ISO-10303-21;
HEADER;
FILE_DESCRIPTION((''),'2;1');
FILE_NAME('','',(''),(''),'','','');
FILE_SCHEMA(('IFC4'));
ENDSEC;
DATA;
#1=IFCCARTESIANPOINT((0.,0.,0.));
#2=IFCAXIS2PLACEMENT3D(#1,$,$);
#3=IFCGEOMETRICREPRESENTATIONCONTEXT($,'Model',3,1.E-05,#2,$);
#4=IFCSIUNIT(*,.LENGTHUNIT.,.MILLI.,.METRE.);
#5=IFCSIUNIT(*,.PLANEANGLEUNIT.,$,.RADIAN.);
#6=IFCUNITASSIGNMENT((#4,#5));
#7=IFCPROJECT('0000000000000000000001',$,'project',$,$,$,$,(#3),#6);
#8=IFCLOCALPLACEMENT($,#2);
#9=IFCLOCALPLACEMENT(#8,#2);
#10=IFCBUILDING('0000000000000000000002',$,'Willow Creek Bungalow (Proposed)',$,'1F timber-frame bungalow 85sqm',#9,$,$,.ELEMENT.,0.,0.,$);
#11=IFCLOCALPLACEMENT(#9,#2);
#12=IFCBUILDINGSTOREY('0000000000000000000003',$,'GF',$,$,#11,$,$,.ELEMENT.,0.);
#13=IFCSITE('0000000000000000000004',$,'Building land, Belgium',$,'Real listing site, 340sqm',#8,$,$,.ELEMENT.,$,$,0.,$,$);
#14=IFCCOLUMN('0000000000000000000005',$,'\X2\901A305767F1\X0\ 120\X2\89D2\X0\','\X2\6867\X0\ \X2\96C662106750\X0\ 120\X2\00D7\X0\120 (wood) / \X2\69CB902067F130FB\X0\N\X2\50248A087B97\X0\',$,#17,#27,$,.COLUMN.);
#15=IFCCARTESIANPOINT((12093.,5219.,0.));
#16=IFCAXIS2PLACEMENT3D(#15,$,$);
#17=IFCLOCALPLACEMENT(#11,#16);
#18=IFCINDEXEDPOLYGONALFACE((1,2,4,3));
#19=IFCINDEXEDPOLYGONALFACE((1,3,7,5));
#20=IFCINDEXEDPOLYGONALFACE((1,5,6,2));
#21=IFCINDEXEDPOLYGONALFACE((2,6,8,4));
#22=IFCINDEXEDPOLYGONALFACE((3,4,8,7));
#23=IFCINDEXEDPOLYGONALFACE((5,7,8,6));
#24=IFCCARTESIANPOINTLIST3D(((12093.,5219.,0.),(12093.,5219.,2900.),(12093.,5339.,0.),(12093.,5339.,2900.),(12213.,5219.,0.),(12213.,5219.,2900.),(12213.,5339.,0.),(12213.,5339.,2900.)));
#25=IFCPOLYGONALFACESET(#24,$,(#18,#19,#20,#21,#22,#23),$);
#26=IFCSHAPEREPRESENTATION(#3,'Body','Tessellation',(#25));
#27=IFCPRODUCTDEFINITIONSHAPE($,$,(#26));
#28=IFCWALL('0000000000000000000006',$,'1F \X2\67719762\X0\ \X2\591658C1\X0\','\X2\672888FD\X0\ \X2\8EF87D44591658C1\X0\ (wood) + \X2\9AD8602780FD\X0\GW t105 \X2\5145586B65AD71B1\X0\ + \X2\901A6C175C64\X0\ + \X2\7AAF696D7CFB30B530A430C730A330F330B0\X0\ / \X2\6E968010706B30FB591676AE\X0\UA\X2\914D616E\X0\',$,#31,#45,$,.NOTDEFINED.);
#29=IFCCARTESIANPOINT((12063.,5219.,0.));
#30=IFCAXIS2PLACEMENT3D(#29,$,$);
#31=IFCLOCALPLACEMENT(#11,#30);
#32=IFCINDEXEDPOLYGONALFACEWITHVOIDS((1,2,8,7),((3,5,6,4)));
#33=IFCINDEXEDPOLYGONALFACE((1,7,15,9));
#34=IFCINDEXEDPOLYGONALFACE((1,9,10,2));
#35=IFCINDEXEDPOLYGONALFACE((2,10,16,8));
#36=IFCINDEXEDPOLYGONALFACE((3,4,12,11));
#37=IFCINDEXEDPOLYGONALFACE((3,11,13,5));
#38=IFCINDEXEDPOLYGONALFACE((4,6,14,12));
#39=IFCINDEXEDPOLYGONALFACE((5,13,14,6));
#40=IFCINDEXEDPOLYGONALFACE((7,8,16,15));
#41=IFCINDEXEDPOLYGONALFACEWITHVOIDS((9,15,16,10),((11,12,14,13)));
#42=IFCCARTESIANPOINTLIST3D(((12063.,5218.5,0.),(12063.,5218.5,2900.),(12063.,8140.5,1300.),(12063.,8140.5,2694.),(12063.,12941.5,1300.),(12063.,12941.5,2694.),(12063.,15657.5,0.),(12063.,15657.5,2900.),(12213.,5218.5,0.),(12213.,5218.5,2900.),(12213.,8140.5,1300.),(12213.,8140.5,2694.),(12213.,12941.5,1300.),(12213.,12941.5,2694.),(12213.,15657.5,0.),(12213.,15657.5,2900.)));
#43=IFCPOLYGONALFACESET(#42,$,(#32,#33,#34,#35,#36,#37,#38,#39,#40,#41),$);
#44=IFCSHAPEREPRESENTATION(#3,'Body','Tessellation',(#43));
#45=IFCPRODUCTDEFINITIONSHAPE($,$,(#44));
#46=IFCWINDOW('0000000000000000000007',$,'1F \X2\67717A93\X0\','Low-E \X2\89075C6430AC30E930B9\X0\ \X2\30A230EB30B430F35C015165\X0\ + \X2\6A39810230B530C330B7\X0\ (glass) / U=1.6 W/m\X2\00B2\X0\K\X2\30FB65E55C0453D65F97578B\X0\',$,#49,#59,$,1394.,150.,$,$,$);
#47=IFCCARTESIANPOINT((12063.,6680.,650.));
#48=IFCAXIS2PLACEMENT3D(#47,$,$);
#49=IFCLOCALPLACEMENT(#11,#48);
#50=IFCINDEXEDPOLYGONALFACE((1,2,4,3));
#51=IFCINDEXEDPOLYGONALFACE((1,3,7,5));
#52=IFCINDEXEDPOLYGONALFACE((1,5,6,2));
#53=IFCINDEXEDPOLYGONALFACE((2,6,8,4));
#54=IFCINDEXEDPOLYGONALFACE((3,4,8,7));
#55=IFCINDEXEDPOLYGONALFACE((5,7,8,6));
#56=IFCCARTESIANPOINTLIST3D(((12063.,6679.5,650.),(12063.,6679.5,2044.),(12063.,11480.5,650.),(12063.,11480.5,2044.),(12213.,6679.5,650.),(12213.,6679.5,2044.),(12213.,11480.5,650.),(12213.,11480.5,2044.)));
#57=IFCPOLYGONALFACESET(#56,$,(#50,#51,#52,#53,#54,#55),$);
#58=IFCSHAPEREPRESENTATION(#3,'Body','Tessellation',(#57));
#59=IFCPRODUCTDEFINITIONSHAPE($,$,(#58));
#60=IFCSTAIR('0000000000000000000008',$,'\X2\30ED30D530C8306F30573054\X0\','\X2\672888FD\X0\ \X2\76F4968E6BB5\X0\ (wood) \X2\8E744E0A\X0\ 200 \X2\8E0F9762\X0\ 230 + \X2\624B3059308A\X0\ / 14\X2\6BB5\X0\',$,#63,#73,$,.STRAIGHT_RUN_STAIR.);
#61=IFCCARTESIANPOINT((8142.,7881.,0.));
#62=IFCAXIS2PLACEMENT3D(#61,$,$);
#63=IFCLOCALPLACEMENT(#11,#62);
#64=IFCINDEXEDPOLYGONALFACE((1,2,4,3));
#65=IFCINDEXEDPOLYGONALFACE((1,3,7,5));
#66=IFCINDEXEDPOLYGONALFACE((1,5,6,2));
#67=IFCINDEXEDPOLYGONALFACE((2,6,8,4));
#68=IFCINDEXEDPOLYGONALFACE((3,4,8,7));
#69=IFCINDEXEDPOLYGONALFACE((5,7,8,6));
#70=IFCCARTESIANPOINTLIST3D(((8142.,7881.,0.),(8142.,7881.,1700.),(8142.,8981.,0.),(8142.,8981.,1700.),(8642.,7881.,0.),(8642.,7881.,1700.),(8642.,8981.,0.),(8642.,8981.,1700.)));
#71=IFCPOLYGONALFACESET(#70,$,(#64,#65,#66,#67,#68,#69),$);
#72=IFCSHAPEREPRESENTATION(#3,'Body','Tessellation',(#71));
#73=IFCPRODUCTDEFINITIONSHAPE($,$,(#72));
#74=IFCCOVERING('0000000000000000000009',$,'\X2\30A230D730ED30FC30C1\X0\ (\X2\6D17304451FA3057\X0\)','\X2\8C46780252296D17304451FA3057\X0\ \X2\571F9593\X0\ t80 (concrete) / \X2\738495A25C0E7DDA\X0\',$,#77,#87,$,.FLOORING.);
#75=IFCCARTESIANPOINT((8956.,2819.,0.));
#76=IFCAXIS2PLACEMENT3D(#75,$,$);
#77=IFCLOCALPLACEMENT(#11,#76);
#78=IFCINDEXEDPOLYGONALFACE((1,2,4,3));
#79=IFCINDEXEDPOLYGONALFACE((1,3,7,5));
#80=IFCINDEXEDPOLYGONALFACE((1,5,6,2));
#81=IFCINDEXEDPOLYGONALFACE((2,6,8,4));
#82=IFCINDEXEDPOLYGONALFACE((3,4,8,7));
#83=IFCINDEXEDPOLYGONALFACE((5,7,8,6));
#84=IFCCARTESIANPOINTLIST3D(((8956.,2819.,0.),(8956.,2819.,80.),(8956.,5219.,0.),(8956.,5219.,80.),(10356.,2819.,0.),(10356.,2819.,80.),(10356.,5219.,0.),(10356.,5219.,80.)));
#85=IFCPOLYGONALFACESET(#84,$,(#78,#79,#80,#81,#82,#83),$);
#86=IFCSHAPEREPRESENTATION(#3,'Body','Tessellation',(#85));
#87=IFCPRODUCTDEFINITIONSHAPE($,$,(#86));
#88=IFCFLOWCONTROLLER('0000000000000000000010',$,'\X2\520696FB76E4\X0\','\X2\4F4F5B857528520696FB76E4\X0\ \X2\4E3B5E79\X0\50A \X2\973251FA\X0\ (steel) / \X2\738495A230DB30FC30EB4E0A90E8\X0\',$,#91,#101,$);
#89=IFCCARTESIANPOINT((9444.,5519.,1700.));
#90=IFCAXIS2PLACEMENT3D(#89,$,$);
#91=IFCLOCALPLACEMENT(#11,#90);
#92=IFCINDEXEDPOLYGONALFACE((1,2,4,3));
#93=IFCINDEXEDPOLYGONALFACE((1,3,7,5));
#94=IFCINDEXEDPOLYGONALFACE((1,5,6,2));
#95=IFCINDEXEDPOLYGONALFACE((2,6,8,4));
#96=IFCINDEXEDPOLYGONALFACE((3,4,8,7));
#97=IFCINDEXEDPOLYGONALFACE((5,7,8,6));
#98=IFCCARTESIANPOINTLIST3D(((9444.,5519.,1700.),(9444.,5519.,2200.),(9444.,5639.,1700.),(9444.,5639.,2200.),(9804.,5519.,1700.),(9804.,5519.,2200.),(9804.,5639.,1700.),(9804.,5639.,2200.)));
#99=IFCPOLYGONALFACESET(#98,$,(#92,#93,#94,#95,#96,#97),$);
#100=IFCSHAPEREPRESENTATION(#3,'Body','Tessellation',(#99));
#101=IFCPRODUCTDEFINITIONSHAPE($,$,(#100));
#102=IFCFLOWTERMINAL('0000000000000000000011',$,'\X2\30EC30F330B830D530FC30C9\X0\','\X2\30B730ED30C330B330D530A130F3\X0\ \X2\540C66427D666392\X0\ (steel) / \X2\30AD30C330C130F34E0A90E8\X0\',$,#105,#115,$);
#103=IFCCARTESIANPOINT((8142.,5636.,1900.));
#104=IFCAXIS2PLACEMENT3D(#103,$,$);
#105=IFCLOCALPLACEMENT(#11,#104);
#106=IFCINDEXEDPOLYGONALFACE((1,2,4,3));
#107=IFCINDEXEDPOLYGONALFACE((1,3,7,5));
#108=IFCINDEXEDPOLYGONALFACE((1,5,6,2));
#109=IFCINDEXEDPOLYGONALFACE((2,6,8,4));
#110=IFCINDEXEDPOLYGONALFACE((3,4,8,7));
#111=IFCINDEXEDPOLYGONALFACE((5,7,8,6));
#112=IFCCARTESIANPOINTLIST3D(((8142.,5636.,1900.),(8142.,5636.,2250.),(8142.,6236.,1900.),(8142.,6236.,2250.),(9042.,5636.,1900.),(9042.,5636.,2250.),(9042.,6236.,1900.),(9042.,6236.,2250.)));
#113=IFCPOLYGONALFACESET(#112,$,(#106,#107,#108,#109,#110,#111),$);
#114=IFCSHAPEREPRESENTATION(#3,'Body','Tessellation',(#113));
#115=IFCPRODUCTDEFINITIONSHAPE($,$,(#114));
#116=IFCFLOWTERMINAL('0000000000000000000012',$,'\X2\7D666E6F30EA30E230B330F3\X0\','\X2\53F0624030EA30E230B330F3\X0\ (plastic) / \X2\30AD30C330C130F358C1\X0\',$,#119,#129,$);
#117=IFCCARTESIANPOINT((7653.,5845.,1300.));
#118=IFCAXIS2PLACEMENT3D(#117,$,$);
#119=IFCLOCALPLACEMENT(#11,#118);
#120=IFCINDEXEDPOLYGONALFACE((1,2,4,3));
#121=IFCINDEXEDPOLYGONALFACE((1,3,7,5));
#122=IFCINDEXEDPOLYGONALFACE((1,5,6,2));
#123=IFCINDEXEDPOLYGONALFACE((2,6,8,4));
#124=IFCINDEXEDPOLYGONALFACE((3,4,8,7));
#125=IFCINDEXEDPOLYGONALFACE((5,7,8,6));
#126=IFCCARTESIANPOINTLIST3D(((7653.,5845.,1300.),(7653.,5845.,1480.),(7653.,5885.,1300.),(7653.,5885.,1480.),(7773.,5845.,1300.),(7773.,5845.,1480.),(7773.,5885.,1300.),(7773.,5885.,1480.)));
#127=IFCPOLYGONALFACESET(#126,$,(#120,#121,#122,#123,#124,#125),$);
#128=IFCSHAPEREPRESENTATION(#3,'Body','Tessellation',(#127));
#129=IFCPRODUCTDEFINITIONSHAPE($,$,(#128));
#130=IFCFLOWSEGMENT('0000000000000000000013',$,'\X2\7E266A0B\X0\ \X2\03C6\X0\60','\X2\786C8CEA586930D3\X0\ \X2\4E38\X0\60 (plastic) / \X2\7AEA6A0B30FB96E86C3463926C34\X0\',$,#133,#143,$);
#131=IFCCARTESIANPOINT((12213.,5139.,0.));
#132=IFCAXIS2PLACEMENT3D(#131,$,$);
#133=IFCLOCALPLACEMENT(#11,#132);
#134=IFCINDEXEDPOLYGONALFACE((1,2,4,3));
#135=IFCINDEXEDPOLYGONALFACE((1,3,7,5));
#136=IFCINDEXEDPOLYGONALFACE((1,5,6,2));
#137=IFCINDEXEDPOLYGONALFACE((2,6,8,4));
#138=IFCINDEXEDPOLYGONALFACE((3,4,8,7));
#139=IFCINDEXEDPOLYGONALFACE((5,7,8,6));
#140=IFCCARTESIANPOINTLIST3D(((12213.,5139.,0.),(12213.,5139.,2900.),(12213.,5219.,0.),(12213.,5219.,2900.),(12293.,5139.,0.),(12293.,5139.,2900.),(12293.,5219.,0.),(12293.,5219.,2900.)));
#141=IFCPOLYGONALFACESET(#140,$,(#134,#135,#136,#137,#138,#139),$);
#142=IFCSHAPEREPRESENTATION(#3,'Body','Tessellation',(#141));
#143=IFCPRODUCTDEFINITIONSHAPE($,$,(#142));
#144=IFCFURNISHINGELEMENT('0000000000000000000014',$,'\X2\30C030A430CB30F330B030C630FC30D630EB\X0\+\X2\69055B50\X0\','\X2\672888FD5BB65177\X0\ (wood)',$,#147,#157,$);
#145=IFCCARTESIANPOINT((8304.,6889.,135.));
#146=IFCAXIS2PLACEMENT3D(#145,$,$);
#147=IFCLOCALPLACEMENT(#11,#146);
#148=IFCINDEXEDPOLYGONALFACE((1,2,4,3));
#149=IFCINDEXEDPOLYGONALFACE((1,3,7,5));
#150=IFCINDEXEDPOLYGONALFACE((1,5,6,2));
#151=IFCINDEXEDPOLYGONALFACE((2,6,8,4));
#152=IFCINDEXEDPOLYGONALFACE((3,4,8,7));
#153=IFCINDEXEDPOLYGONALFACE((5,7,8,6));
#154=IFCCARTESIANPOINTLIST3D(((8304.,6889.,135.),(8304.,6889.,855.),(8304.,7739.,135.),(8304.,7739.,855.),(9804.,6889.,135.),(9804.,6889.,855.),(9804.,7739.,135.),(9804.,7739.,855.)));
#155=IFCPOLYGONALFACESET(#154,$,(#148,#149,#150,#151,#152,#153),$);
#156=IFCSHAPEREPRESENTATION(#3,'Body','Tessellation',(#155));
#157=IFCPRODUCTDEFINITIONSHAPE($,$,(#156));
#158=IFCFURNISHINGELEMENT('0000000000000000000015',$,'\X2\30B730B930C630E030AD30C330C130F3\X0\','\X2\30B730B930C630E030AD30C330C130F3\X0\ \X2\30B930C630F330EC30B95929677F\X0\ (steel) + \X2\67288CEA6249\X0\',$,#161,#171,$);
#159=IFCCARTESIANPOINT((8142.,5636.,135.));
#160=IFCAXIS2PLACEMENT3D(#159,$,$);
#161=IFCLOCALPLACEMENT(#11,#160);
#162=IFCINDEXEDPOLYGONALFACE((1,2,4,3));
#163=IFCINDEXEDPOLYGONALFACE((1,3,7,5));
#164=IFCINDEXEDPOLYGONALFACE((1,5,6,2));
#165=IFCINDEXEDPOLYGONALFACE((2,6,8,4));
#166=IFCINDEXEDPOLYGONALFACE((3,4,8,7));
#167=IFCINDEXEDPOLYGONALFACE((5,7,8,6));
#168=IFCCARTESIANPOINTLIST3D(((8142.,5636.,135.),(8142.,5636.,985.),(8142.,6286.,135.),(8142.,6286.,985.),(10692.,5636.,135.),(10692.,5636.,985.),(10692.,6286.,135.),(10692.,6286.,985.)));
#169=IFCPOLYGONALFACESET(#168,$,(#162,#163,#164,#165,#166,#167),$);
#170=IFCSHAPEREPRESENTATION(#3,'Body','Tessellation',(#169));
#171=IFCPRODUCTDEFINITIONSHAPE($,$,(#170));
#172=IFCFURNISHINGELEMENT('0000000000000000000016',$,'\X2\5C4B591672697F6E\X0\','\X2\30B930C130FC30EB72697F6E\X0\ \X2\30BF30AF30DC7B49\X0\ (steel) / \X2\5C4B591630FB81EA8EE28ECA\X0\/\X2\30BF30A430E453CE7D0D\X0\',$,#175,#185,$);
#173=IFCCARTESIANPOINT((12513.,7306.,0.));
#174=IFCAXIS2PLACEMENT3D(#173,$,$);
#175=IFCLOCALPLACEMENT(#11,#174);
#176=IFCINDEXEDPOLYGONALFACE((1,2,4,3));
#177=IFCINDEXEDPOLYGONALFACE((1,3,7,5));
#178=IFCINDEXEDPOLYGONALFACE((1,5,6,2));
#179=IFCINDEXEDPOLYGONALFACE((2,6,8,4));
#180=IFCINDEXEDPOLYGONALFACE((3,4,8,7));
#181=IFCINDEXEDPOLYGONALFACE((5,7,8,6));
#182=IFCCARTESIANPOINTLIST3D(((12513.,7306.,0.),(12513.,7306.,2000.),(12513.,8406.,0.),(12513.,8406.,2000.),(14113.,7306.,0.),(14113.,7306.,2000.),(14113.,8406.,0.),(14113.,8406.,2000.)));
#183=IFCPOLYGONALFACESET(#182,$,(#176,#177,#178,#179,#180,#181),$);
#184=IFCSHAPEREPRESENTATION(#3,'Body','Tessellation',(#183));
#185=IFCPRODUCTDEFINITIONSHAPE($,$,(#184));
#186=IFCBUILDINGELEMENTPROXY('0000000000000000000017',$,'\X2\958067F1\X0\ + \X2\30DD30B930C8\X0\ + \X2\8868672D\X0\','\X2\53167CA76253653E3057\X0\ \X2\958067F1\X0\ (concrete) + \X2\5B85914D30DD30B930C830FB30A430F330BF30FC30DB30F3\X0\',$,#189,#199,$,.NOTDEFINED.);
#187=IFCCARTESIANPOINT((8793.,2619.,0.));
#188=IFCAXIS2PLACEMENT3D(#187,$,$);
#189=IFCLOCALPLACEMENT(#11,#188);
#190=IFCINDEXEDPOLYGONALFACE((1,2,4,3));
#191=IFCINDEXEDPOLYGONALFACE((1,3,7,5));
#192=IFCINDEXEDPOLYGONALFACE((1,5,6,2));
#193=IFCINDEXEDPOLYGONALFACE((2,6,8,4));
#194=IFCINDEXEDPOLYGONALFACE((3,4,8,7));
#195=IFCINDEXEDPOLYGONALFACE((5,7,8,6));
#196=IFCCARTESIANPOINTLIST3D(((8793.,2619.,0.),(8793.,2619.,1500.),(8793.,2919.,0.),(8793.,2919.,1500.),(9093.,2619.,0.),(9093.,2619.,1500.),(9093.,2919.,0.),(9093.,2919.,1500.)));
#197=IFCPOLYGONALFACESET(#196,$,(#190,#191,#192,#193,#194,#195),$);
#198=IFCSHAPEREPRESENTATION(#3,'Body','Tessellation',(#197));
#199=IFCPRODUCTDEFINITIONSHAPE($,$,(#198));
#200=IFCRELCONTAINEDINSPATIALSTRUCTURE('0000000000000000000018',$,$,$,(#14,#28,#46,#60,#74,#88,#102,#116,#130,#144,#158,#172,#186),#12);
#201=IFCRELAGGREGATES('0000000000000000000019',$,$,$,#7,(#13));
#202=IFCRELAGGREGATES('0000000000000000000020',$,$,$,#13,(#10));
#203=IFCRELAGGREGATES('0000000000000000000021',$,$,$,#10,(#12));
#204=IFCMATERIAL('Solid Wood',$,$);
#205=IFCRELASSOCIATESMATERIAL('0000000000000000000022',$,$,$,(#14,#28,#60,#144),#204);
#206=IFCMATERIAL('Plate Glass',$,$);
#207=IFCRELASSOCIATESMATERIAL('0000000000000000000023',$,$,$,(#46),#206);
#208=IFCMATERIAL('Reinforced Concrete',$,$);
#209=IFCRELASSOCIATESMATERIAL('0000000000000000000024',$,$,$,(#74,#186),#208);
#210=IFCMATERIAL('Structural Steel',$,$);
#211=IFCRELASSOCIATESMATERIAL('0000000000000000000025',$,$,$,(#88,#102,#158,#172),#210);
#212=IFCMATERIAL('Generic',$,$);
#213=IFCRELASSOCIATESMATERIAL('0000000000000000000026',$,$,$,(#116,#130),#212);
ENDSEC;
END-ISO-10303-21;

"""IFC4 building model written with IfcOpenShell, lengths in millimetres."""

from ifc_helpers import new_model, si_unit, frame, frame_2d, origin, place, context, project, spatial, rectangle, extrude, material, element, fill, save


model = new_model("IFC4")

# Units and contexts
model_context = context("Model", 3, precision=1e-05, world=origin())
ifc_project = project(units=[si_unit("LENGTHUNIT", "METRE", prefix="MILLI"), si_unit("PLANEANGLEUNIT", "RADIAN")], contexts=[model_context])

# Site, building, storey
site_placement = place(None, origin())
site = spatial("IfcSite", under=ifc_project, at=site_placement, Name="Building land, Belgium", ObjectType="Real listing site, 340sqm", CompositionType="ELEMENT", RefElevation=0.0)
building_placement = place(site_placement, origin())
building = spatial("IfcBuilding", under=site, at=building_placement, Name="Willow Creek Bungalow (Proposed)", ObjectType="1F timber-frame bungalow 85sqm", CompositionType="ELEMENT", ElevationOfRefHeight=0.0, ElevationOfTerrain=0.0)
storey_placement = place(building_placement, origin())
storey = spatial("IfcBuildingStorey", under=building, at=storey_placement, Name="GF", CompositionType="ELEMENT", Elevation=0.0)

# Column
ifc_material_1 = material(Name="Solid Wood")
column_1_placement = place(storey_placement, frame((12093.0, 5219.0, 0.0)))
element("IfcColumn", 1, at=column_1_placement, inside=storey, material=ifc_material_1, Name="通し柱 120角", Description="桧 集成材 120×120 (wood) / 構造柱・N値計算", PredefinedType="COLUMN", context=model_context, shape_type="SweptSolid", body=[
    extrude(rectangle(XDim=120.0, YDim=120.0, at=frame_2d((60.0, 60.0))), frame((12093.0, 5219.0, 0.0)), (0.0, 0.0, 1.0), 2900.0),
])

# Wall, opening, window
wall_1_placement = place(storey_placement, frame((12063.0, 5219.0, 0.0)))
wall_1 = element("IfcWall", 2, at=wall_1_placement, inside=storey, material=ifc_material_1, Name="1F 東面 外壁", Description="木製 軸組外壁 (wood) + 高性能GW t105 充填断熱 + 通気層 + 窯業系サイディング / 準耐火・外皮UA配慮", PredefinedType="NOTDEFINED", context=model_context, shape_type="SweptSolid", body=[
    extrude(rectangle(XDim=150.0, YDim=10439.0, at=frame_2d((75.0, 5219.0))), frame((12063.0, 5219.0, 0.0)), (0.0, 0.0, 1.0), 2900.0),
])
opening_placement = place(storey_placement, frame((12063.0, 6680.0, 650.0)))
opening = element("IfcOpeningElement", 3, at=opening_placement, cuts=wall_1, PredefinedType="NOTDEFINED", context=model_context, shape_type="SweptSolid", body=[
    extrude(rectangle(XDim=150.0, YDim=4801.0, at=frame_2d((75.0, 2400.0))), frame((12063.0, 6680.0, 650.0)), (0.0, 0.0, 1.0), 1394.0),
])
ifc_material_2 = material(Name="Plate Glass")
window_placement = place(storey_placement, frame((12063.0, 6680.0, 650.0)))
window = element("IfcWindow", 4, at=window_placement, inside=storey, material=ifc_material_2, Name="1F 東窓", Description="Low-E 複層ガラス アルゴン封入 + 樹脂サッシ (glass) / U=1.6 W/m²K・日射取得型", OverallHeight=1394.0, OverallWidth=150.0, context=model_context, shape_type="SweptSolid", body=[
    extrude(rectangle(XDim=150.0, YDim=4801.0, at=frame_2d((75.0, 2400.0))), frame((12063.0, 6680.0, 650.0)), (0.0, 0.0, 1.0), 1394.0),
])
fill(opening, window)

# Stair
stair_placement = place(storey_placement, frame((8142.0, 7881.0, 0.0)))
element("IfcStair", 5, at=stair_placement, inside=storey, material=ifc_material_1, Name="ロフトはしご", Description="木製 直階段 (wood) 蹴上 200 踏面 230 + 手すり / 14段", PredefinedType="STRAIGHT_RUN_STAIR", context=model_context, shape_type="SweptSolid", body=[
    extrude(rectangle(XDim=500.0, YDim=1100.0, at=frame_2d((250.0, 550.0))), frame((8142.0, 7881.0, 0.0)), (0.0, 0.0, 1.0), 1700.0),
])

# Covering
ifc_material_3 = material(Name="Reinforced Concrete")
covering_placement = place(storey_placement, frame((8956.0, 2819.0, 0.0)))
element("IfcCovering", 6, at=covering_placement, inside=storey, material=ifc_material_3, Name="アプローチ (洗い出し)", Description="豆砂利洗い出し 土間 t80 (concrete) / 玄関導線", PredefinedType="FLOORING", context=model_context, shape_type="SweptSolid", body=[
    extrude(rectangle(XDim=1400.0, YDim=2400.0, at=frame_2d((700.0, 1200.0))), frame((8956.0, 2819.0, 0.0)), (0.0, 0.0, 1.0), 80.0),
])

# Flow controller
ifc_material_4 = material(Name="Structural Steel")
flow_controller_placement = place(storey_placement, frame((9444.0, 5519.0, 1700.0)))
element("IfcFlowController", 7, at=flow_controller_placement, inside=storey, material=ifc_material_4, Name="分電盤", Description="住宅用分電盤 主幹50A 露出 (steel) / 玄関ホール上部", context=model_context, shape_type="SweptSolid", body=[
    extrude(rectangle(XDim=360.0, YDim=120.0, at=frame_2d((180.0, 60.0))), frame((9444.0, 5519.0, 1700.0)), (0.0, 0.0, 1.0), 500.0),
])

# Flow terminals
flow_terminal_1_placement = place(storey_placement, frame((8142.0, 5636.0, 1900.0)))
element("IfcFlowTerminal", 8, at=flow_terminal_1_placement, inside=storey, material=ifc_material_4, Name="レンジフード", Description="シロッコファン 同時給排 (steel) / キッチン上部", context=model_context, shape_type="SweptSolid", body=[
    extrude(rectangle(XDim=900.0, YDim=600.0, at=frame_2d((450.0, 300.0))), frame((8142.0, 5636.0, 1900.0)), (0.0, 0.0, 1.0), 350.0),
])
ifc_material_5 = material(Name="Generic")
flow_terminal_2_placement = place(storey_placement, frame((7653.0, 5845.0, 1300.0)))
element("IfcFlowTerminal", 9, at=flow_terminal_2_placement, inside=storey, material=ifc_material_5, Name="給湯リモコン", Description="台所リモコン (plastic) / キッチン壁", context=model_context, shape_type="SweptSolid", body=[
    extrude(rectangle(XDim=120.0, YDim=40.0, at=frame_2d((60.0, 20.0))), frame((7653.0, 5845.0, 1300.0)), (0.0, 0.0, 1.0), 180.0),
])

# Flow segment
flow_segment_placement = place(storey_placement, frame((12213.0, 5139.0, 0.0)))
element("IfcFlowSegment", 10, at=flow_segment_placement, inside=storey, material=ifc_material_5, Name="縦樋 φ60", Description="硬質塩ビ 丸60 (plastic) / 竪樋・雨水排水", context=model_context, shape_type="SweptSolid", body=[
    extrude(rectangle(XDim=80.0, YDim=80.0, at=frame_2d((40.0, 40.0))), frame((12213.0, 5139.0, 0.0)), (0.0, 0.0, 1.0), 2900.0),
])

# Furnishing elements
furnishing_1_placement = place(storey_placement, frame((8304.0, 6889.0, 135.0)))
element("IfcFurnishingElement", 11, at=furnishing_1_placement, inside=storey, material=ifc_material_1, Name="ダイニングテーブル+椅子", Description="木製家具 (wood)", context=model_context, shape_type="SweptSolid", body=[
    extrude(rectangle(XDim=1500.0, YDim=850.0, at=frame_2d((750.0, 425.0))), frame((8304.0, 6889.0, 135.0)), (0.0, 0.0, 1.0), 720.0),
])
furnishing_2_placement = place(storey_placement, frame((8142.0, 5636.0, 135.0)))
element("IfcFurnishingElement", 12, at=furnishing_2_placement, inside=storey, material=ifc_material_4, Name="システムキッチン", Description="システムキッチン ステンレス天板 (steel) + 木質扉", context=model_context, shape_type="SweptSolid", body=[
    extrude(rectangle(XDim=2550.0, YDim=650.0, at=frame_2d((1275.0, 325.0))), frame((8142.0, 5636.0, 135.0)), (0.0, 0.0, 1.0), 850.0),
])
furnishing_3_placement = place(storey_placement, frame((12513.0, 7306.0, 0.0)))
element("IfcFurnishingElement", 13, at=furnishing_3_placement, inside=storey, material=ifc_material_4, Name="屋外物置", Description="スチール物置 タクボ等 (steel) / 屋外・自転車/タイヤ収納", context=model_context, shape_type="SweptSolid", body=[
    extrude(rectangle(XDim=1600.0, YDim=1100.0, at=frame_2d((800.0, 550.0))), frame((12513.0, 7306.0, 0.0)), (0.0, 0.0, 1.0), 2000.0),
])

# Building element proxy
proxy_placement = place(storey_placement, frame((8793.0, 2619.0, 0.0)))
element("IfcBuildingElementProxy", 14, at=proxy_placement, inside=storey, material=ifc_material_3, Name="門柱 + ポスト + 表札", Description="化粧打放し 門柱 (concrete) + 宅配ポスト・インターホン", PredefinedType="NOTDEFINED", context=model_context, shape_type="SweptSolid", body=[
    extrude(rectangle(XDim=300.0, YDim=300.0, at=frame_2d((150.0, 150.0))), frame((8793.0, 2619.0, 0.0)), (0.0, 0.0, 1.0), 1500.0),
])

save(model, "model.ifc")
